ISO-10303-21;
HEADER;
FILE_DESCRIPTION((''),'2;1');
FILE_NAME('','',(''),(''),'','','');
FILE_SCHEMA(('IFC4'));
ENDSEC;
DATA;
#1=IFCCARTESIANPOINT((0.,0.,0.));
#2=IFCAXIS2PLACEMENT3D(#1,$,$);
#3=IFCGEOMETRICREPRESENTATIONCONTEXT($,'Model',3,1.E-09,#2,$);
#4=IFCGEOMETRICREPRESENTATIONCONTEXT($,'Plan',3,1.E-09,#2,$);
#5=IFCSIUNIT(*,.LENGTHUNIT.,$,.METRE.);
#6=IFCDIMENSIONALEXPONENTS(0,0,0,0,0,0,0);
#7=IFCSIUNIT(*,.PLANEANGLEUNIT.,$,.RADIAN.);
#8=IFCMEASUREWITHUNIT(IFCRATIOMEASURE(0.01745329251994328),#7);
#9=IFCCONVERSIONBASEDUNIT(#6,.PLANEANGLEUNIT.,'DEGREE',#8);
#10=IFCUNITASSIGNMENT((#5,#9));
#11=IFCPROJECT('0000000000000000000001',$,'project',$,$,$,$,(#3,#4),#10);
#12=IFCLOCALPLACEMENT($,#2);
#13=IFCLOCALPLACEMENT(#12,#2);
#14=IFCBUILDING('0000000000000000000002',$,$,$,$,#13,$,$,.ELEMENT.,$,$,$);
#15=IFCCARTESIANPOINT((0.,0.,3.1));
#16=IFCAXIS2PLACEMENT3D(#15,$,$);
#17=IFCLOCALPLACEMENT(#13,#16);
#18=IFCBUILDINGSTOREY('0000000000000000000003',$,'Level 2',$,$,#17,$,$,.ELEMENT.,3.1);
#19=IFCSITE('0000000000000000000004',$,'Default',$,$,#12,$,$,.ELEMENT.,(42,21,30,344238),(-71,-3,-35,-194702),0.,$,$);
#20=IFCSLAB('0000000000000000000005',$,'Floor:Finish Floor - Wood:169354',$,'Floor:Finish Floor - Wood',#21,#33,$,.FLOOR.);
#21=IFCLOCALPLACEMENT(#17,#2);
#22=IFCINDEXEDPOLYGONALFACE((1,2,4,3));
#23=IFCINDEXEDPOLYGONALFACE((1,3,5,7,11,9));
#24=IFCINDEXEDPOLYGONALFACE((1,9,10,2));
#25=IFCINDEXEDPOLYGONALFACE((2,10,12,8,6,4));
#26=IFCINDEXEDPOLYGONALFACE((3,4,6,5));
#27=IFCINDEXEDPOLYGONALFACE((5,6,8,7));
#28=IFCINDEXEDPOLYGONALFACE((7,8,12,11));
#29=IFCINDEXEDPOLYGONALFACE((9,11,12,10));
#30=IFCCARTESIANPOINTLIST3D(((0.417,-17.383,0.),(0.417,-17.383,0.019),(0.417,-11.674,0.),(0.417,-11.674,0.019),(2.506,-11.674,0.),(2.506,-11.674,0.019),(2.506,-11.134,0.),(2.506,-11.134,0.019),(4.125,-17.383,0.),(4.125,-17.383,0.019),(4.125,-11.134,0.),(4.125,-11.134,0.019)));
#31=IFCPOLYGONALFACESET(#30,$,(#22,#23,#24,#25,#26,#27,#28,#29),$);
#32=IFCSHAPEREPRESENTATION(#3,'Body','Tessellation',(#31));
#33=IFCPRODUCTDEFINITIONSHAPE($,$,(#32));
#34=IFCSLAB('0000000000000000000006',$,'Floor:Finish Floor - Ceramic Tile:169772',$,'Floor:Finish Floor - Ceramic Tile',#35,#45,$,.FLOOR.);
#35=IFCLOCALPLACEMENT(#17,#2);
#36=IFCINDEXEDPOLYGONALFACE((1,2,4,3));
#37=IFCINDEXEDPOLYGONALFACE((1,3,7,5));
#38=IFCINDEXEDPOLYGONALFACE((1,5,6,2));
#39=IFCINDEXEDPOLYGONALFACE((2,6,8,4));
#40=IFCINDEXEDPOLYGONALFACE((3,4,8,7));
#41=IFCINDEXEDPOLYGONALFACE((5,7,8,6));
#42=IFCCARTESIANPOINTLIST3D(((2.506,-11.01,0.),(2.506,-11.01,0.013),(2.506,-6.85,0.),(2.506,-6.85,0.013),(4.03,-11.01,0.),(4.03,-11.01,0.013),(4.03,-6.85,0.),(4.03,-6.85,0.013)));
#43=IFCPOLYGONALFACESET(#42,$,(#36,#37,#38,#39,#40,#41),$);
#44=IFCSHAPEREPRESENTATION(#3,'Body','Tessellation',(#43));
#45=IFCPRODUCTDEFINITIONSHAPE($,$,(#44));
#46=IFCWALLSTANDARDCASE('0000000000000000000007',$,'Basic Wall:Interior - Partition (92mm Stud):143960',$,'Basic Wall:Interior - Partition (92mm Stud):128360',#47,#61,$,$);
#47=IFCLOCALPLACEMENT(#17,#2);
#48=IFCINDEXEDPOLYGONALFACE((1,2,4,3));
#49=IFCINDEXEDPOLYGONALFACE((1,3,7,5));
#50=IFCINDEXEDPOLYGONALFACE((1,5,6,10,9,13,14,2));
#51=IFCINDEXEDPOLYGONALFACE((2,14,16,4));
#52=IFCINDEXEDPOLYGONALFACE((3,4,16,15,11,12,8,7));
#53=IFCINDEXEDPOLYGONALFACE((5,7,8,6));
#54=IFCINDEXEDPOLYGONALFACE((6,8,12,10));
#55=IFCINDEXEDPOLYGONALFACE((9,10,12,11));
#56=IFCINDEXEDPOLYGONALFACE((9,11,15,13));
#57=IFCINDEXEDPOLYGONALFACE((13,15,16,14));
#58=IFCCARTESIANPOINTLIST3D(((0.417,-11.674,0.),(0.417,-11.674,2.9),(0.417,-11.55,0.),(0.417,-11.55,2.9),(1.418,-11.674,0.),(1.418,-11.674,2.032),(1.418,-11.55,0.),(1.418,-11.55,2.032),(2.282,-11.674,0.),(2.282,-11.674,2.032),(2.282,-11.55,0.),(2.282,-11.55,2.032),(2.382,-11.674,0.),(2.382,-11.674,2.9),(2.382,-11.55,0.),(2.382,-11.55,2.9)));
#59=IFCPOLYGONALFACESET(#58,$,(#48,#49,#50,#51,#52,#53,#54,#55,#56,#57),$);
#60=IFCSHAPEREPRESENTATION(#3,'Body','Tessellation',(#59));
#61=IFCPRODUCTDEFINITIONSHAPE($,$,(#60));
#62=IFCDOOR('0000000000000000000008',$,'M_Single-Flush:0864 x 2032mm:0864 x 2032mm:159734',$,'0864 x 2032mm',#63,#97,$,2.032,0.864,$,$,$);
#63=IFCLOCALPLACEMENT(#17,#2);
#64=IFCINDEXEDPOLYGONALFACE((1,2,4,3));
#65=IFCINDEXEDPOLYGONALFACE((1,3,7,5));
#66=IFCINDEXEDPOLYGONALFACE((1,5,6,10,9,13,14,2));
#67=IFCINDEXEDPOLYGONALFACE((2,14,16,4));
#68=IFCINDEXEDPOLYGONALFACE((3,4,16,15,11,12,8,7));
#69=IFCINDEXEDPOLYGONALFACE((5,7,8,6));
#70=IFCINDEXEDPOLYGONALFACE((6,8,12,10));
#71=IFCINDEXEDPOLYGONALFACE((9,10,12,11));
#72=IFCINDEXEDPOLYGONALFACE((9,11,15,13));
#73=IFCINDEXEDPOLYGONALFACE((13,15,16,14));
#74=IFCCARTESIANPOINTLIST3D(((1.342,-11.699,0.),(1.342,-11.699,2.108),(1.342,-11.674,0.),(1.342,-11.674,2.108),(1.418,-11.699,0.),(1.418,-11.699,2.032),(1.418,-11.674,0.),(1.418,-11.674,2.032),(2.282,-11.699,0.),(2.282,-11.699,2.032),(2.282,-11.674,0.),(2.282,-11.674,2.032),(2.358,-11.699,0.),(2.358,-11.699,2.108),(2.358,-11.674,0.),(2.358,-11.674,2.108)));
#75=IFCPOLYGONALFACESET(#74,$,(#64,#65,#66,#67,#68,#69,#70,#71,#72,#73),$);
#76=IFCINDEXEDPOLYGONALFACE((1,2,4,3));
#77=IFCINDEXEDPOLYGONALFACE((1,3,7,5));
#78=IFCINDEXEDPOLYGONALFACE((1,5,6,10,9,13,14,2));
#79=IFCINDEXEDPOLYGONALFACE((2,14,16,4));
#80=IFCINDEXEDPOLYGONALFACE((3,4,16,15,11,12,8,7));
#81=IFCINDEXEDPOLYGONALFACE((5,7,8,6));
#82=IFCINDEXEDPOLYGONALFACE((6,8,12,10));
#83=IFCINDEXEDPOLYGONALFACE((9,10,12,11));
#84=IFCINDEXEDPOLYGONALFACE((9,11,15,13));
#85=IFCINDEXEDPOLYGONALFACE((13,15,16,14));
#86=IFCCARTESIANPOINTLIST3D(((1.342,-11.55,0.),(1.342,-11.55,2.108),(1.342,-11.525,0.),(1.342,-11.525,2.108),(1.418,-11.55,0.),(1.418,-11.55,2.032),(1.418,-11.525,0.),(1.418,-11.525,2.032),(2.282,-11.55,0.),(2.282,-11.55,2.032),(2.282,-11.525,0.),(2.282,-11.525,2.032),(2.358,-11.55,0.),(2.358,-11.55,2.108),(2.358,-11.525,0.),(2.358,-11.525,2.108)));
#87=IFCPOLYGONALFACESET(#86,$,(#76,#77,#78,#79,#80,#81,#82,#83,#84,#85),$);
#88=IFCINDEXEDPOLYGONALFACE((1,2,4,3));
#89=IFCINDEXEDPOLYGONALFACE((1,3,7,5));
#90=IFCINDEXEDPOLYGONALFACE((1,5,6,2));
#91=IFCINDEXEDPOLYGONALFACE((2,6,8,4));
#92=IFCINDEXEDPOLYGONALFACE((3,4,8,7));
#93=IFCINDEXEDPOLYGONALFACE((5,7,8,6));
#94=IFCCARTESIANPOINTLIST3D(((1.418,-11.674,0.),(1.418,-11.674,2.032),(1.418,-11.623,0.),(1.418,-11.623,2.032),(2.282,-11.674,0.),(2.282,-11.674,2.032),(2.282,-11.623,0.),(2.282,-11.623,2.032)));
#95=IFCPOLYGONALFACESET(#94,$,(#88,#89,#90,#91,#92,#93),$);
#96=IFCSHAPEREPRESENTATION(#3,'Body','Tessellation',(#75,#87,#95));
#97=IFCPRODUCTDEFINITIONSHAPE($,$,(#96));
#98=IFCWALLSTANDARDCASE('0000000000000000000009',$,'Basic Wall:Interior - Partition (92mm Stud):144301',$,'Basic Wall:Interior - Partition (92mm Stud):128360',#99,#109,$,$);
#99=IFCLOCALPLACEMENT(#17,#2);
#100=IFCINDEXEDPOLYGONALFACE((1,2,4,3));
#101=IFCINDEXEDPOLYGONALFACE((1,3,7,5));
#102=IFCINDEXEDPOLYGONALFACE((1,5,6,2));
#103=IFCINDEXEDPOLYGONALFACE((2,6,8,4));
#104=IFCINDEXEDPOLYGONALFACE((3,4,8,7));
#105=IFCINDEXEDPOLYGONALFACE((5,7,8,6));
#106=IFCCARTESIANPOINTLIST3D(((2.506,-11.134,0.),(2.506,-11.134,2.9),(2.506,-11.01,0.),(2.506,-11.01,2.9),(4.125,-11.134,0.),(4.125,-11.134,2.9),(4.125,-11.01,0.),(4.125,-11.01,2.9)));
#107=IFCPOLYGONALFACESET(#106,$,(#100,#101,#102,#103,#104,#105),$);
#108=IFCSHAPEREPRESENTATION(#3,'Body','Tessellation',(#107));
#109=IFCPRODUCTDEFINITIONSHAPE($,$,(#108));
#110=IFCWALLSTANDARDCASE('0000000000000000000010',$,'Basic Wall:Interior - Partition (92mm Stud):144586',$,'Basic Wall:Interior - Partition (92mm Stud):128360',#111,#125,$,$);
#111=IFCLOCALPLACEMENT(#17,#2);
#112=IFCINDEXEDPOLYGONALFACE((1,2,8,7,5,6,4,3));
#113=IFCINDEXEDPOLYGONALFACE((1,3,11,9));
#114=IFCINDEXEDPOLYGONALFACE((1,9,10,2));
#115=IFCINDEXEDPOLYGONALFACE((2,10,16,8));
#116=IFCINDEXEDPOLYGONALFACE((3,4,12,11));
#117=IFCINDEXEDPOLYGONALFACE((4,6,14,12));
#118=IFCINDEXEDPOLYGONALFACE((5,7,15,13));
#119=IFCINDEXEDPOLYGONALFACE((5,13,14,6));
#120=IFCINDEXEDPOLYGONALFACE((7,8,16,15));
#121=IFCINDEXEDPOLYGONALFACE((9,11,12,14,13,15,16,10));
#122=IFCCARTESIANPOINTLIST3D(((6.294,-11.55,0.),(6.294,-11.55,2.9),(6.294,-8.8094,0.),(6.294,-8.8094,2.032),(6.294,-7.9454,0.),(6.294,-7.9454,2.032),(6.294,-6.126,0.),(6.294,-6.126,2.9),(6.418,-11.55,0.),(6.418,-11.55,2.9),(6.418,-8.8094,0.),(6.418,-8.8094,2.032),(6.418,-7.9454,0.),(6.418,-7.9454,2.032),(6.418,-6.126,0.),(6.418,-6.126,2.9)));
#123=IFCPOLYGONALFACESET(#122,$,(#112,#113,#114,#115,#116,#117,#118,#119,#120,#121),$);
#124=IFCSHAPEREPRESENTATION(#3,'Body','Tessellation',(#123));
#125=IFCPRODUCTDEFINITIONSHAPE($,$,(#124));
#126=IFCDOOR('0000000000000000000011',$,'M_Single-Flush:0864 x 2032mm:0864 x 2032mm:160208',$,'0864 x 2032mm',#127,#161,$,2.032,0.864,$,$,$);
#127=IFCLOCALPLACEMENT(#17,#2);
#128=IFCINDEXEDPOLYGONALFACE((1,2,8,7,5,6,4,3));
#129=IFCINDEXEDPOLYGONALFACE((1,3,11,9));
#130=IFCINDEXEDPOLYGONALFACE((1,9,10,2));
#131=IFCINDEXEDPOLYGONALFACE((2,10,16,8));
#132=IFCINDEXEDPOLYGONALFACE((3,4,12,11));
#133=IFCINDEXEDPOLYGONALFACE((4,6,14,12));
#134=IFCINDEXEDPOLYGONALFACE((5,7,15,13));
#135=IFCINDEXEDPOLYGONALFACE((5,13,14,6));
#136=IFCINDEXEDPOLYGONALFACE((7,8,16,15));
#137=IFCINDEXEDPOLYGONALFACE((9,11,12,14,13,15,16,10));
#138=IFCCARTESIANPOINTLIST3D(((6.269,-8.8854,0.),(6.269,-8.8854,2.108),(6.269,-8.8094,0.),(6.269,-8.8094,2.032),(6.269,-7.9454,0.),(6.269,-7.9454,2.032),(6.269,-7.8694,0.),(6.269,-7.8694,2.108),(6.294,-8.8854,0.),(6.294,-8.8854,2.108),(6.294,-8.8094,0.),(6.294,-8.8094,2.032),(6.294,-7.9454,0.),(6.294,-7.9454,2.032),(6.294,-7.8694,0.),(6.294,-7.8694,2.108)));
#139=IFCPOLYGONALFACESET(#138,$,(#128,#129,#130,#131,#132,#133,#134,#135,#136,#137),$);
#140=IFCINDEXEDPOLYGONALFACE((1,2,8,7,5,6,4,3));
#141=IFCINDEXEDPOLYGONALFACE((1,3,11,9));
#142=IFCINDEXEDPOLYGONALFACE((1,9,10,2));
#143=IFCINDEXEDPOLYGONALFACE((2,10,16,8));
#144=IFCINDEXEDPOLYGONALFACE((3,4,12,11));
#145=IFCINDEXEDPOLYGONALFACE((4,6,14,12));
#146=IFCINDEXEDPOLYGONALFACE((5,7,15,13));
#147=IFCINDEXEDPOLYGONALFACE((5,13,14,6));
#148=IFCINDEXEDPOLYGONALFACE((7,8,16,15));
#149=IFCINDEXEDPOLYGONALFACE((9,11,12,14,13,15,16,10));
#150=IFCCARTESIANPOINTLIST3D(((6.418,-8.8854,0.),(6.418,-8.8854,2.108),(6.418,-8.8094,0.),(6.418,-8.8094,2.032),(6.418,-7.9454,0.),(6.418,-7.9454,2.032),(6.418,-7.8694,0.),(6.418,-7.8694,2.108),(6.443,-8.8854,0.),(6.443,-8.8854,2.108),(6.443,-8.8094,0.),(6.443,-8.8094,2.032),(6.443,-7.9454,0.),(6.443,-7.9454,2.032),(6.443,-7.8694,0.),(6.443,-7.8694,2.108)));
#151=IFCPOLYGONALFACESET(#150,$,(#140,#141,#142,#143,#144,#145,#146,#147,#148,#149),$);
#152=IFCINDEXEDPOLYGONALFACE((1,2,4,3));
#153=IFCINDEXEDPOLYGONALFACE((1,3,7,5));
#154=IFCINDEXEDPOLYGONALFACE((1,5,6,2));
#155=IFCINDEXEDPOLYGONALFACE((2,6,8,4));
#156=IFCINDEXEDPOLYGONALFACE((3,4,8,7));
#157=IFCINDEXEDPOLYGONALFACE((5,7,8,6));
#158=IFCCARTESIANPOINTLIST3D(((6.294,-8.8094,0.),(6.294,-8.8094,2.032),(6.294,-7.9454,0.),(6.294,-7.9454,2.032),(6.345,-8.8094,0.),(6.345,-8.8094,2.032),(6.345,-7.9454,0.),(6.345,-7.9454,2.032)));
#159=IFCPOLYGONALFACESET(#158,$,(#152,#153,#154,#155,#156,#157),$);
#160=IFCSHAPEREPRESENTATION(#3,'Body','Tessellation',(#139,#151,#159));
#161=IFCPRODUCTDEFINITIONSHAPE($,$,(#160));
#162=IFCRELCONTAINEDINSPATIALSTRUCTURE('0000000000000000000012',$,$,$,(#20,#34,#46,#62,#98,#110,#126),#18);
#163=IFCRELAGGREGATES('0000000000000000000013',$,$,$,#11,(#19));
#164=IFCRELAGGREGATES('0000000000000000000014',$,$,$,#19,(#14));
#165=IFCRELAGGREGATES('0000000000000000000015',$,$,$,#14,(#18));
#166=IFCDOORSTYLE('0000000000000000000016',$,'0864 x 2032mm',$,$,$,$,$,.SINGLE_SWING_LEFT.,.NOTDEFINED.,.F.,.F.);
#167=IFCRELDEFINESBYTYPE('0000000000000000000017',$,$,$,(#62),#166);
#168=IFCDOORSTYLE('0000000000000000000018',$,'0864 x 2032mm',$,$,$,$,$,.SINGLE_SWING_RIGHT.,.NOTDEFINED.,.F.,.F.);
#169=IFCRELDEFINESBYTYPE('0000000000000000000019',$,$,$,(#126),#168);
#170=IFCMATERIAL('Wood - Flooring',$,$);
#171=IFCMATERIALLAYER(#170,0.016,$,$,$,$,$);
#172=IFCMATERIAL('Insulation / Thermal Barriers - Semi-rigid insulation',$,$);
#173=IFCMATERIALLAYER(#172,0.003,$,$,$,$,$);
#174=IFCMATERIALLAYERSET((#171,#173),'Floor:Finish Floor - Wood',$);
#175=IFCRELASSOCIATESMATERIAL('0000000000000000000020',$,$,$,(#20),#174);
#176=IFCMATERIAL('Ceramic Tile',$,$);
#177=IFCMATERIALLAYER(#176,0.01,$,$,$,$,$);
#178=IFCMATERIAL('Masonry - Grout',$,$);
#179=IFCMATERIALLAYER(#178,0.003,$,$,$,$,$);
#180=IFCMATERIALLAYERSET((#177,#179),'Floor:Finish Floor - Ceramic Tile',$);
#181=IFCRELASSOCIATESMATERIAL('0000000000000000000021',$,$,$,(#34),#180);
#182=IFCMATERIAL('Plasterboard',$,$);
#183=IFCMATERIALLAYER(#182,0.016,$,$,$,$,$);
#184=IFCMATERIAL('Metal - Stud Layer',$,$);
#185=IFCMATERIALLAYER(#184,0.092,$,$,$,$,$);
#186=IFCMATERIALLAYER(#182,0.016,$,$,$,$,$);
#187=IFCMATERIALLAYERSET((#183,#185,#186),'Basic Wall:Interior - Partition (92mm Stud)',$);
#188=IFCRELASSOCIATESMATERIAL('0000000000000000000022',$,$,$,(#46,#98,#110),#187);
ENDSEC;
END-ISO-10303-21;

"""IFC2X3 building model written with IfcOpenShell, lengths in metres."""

from ifc_helpers import new_model, entity, si_unit, converted_unit, frame, frame_2d, origin, origin_2d_with_axis, place, context, project, spatial, polyline, rectangle, outline, extrude, source, transform, mapped, material, layer, layer_set, layer_usage, type_object, type_shapes, element, fill, save


model = new_model("IFC2X3")

# Units and contexts
model_context = context("Model", 3, precision=1e-09, world=origin())
plan_context = context("Plan", 3, precision=1e-09, world=origin())
ifc_project = project(units=[si_unit("LENGTHUNIT", "METRE"), converted_unit("PLANEANGLEUNIT", "DEGREE", entity("IfcRatioMeasure", 0.01745329251994328), si_unit("PLANEANGLEUNIT", "RADIAN"), dimensions=[0, 0, 0, 0, 0, 0, 0])], contexts=[model_context, plan_context])

# Site, building, storey
site_placement = place(None, origin())
site = spatial("IfcSite", under=ifc_project, at=site_placement, Name="Default", CompositionType="ELEMENT", RefLatitude=(42, 21, 30, 344238), RefLongitude=(-71, -3, -35, -194702), RefElevation=0.0)
building_placement = place(site_placement, origin())
building = spatial("IfcBuilding", under=site, at=building_placement, CompositionType="ELEMENT")
storey_placement = place(building_placement, frame((0.0, 0.0, 3.1)))
storey = spatial("IfcBuildingStorey", under=building, at=storey_placement, Name="Level 2", CompositionType="ELEMENT", Elevation=3.1)

# Slabs
ifc_material_1 = material(Name="Wood - Flooring")
ifc_layer_1 = layer(ifc_material_1, 0.016)
ifc_material_2 = material(Name="Insulation / Thermal Barriers - Semi-rigid insulation")
ifc_layer_2 = layer(ifc_material_2, 0.003)
ifc_layer_set_1 = layer_set([ifc_layer_1, ifc_layer_2], Name="Floor:Finish Floor - Wood")
ifc_layer_usage_1 = layer_usage(ifc_layer_set_1, "AXIS3", "POSITIVE", 0.0)
slab_1_placement = place(storey_placement, frame((0.417, -17.383, 0.0)))
element("IfcSlab", 1, at=slab_1_placement, inside=storey, material=ifc_layer_usage_1, Name="Floor:Finish Floor - Wood:169354", ObjectType="Floor:Finish Floor - Wood", PredefinedType="FLOOR", context=model_context, shape_type="SweptSolid", body=[
    extrude(outline(polyline([(-1.854, -3.1245), (1.854, -3.1245), (1.854, 2.5845), (-0.235, 2.5845), (-0.235, 3.1245), (-1.854, 3.1245), (-1.854, -3.1245)])), frame((1.854, 3.1245, 0.019), z_axis=(0.0, 0.0, -1.0), x_axis=(-1.0, 0.0, 0.0)), (0.0, 0.0, 1.0), 0.019),
])
ifc_material_3 = material(Name="Ceramic Tile")
ifc_layer_3 = layer(ifc_material_3, 0.01)
ifc_material_4 = material(Name="Masonry - Grout")
ifc_layer_4 = layer(ifc_material_4, 0.003)
ifc_layer_set_2 = layer_set([ifc_layer_3, ifc_layer_4], Name="Floor:Finish Floor - Ceramic Tile")
ifc_layer_usage_2 = layer_usage(ifc_layer_set_2, "AXIS3", "POSITIVE", 0.0)
slab_2_placement = place(storey_placement, frame((2.506, -11.01, 0.0)))
element("IfcSlab", 2, at=slab_2_placement, inside=storey, material=ifc_layer_usage_2, Name="Floor:Finish Floor - Ceramic Tile:169772", ObjectType="Floor:Finish Floor - Ceramic Tile", PredefinedType="FLOOR", context=model_context, shape_type="SweptSolid", body=[
    extrude(rectangle(XDim=4.16, YDim=1.524, at=frame_2d((0.0, 0.0), x_axis=(0.0, -1.0))), frame((0.762, 2.08, 0.013), z_axis=(0.0, 0.0, -1.0), x_axis=(-1.0, 0.0, 0.0)), (0.0, 0.0, 1.0), 0.013),
])

# Shared definitions
ifc_material_5 = material(Name="Metal - Stud Layer")
ifc_material_6 = material(Name="Plasterboard")

# Wall, opening, door
ifc_layer_5 = layer(ifc_material_6, 0.016)
ifc_layer_6 = layer(ifc_material_5, 0.092)
ifc_layer_7 = layer(ifc_material_6, 0.016)
ifc_layer_set_3 = layer_set([ifc_layer_5, ifc_layer_6, ifc_layer_7], Name="Basic Wall:Interior - Partition (92mm Stud)")
ifc_layer_usage_3 = layer_usage(ifc_layer_set_3, "AXIS2", "NEGATIVE", 0.062)
wall_1_placement = place(storey_placement, frame((2.382, -11.612, 0.0), z_axis=(0.0, 0.0, 1.0), x_axis=(-1.0, 0.0, 0.0)))
wall_1 = element("IfcWallStandardCase", 3, at=wall_1_placement, inside=storey, material=ifc_layer_usage_3, Name="Basic Wall:Interior - Partition (92mm Stud):143960", ObjectType="Basic Wall:Interior - Partition (92mm Stud):128360", context=model_context, shape_type="SweptSolid", body=[
    extrude(rectangle(XDim=1.965, YDim=0.124, at=frame_2d((0.9825, 0.0), x_axis=(-1.0, 0.0))), origin(), (0.0, 0.0, 1.0), 2.9),
])
opening_1_placement = place(wall_1_placement, frame((0.1, -0.062, 0.0)))
opening_1 = element("IfcOpeningElement", 4, at=opening_1_placement, cuts=wall_1, ObjectType="Opening", context=model_context, shape_type="SweptSolid", body=[
    extrude(rectangle(XDim=0.864, YDim=2.032, at=frame_2d((1.016, 0.432), x_axis=(0.0, -1.0))), frame((0.0, 0.0, 0.0), z_axis=(0.0, 1.0, 0.0), x_axis=(0.0, 0.0, 1.0)), (0.0, 0.0, 1.0), 0.124),
])
door_style_1 = type_object("IfcDoorStyle", Name="0864 x 2032mm", ConstructionType="NOTDEFINED", OperationType="SINGLE_SWING_LEFT", ParameterTakesPrecedence=False, Sizeable=False)
shared_shape_1 = source(origin(), model_context, "Body", "SweptSolid", [
    extrude(outline(polyline([(-0.508, -1.073), (0.508, -1.073), (0.508, 1.035), (0.432, 1.035), (0.432, -0.997), (-0.432, -0.997), (-0.432, 1.035), (-0.508, 1.035), (-0.508, -1.073)])), frame((0.432, 0.149, 1.035), z_axis=(0.0, -1.0, 0.0), x_axis=(-1.0, 0.0, 0.0)), (0.0, 0.0, 1.0), 0.025),
    extrude(outline(polyline([(-1.073, -0.508), (1.035, -0.508), (1.035, -0.432), (-0.997, -0.432), (-0.997, 0.432), (1.035, 0.432), (1.035, 0.508), (-1.073, 0.508), (-1.073, -0.508)])), frame((0.432, 0.0, 1.035), z_axis=(0.0, -1.0, 0.0), x_axis=(0.0, 0.0, -1.0)), (0.0, 0.0, 1.0), 0.025),
    extrude(rectangle(XDim=0.864, YDim=0.051, at=origin_2d_with_axis()), frame((0.432, 0.0985, 0.0)), (0.0, 0.0, 1.0), 2.032),
])
type_shapes(door_style_1, [shared_shape_1])
door_1_placement = place(opening_1_placement, origin())
door_1 = element("IfcDoor", 5, at=door_1_placement, inside=storey, type_object=door_style_1, Name="M_Single-Flush:0864 x 2032mm:0864 x 2032mm:159734", ObjectType="0864 x 2032mm", OverallHeight=2.032, OverallWidth=0.864, context=model_context, shape_type="MappedRepresentation", body=[
    mapped(shared_shape_1, transform((0.0, 0.0, 0.0), scale=1.0)),
])
fill(opening_1, door_1)

# Wall
ifc_layer_usage_4 = layer_usage(ifc_layer_set_3, "AXIS2", "NEGATIVE", 0.062)
wall_2_placement = place(storey_placement, frame((4.125, -11.072, 0.0), z_axis=(0.0, 0.0, 1.0), x_axis=(-1.0, 0.0, 0.0)))
element("IfcWallStandardCase", 6, at=wall_2_placement, inside=storey, material=ifc_layer_usage_4, Name="Basic Wall:Interior - Partition (92mm Stud):144301", ObjectType="Basic Wall:Interior - Partition (92mm Stud):128360", context=model_context, shape_type="SweptSolid", body=[
    extrude(rectangle(XDim=1.619, YDim=0.124, at=frame_2d((0.8095, 0.0), x_axis=(-1.0, 0.0))), origin(), (0.0, 0.0, 1.0), 2.9),
])

# Wall, opening, door
ifc_layer_usage_5 = layer_usage(ifc_layer_set_3, "AXIS2", "NEGATIVE", 0.062)
wall_3_placement = place(storey_placement, frame((6.356, -11.55, 0.0), z_axis=(0.0, 0.0, 1.0), x_axis=(0.0, 1.0, 0.0)))
wall_3 = element("IfcWallStandardCase", 7, at=wall_3_placement, inside=storey, material=ifc_layer_usage_5, Name="Basic Wall:Interior - Partition (92mm Stud):144586", ObjectType="Basic Wall:Interior - Partition (92mm Stud):128360", context=model_context, shape_type="SweptSolid", body=[
    extrude(rectangle(XDim=5.424, YDim=0.124, at=frame_2d((2.712, 0.0), x_axis=(-1.0, 0.0))), origin(), (0.0, 0.0, 1.0), 2.9),
])
opening_2_placement = place(wall_3_placement, frame((2.7406, -0.062, 0.0)))
opening_2 = element("IfcOpeningElement", 8, at=opening_2_placement, cuts=wall_3, ObjectType="Opening", context=model_context, shape_type="SweptSolid", body=[
    extrude(rectangle(XDim=0.864, YDim=2.032, at=frame_2d((1.016, 0.432), x_axis=(0.0, 1.0))), frame((0.0, 0.0, 0.0), z_axis=(0.0, 1.0, 0.0), x_axis=(0.0, 0.0, 1.0)), (0.0, 0.0, 1.0), 0.124),
])
door_style_2 = type_object("IfcDoorStyle", Name="0864 x 2032mm", ConstructionType="NOTDEFINED", OperationType="SINGLE_SWING_RIGHT", ParameterTakesPrecedence=False, Sizeable=False)
shared_shape_2 = source(origin(), model_context, "Body", "SweptSolid", [
    extrude(outline(polyline([(-0.508, -1.073), (0.508, -1.073), (0.508, 1.035), (0.432, 1.035), (0.432, -0.997), (-0.432, -0.997), (-0.432, 1.035), (-0.508, 1.035), (-0.508, -1.073)])), frame((0.432, 0.124, 1.035), z_axis=(0.0, 1.0, 0.0), x_axis=(1.0, 0.0, 0.0)), (0.0, 0.0, 1.0), 0.025),
    extrude(outline(polyline([(-1.073, -0.508), (1.035, -0.508), (1.035, -0.432), (-0.997, -0.432), (-0.997, 0.432), (1.035, 0.432), (1.035, 0.508), (-1.073, 0.508), (-1.073, -0.508)])), frame((0.432, -0.025, 1.035), z_axis=(0.0, 1.0, 0.0), x_axis=(0.0, 0.0, -1.0)), (0.0, 0.0, 1.0), 0.025),
    extrude(rectangle(XDim=0.051, YDim=0.864, at=origin_2d_with_axis()), frame((0.432, 0.0985, 0.0), z_axis=(0.0, 0.0, 1.0), x_axis=(0.0, 1.0, 0.0)), (0.0, 0.0, 1.0), 2.032),
])
type_shapes(door_style_2, [shared_shape_2])
door_2_placement = place(opening_2_placement, origin())
door_2 = element("IfcDoor", 9, at=door_2_placement, inside=storey, type_object=door_style_2, Name="M_Single-Flush:0864 x 2032mm:0864 x 2032mm:160208", ObjectType="0864 x 2032mm", OverallHeight=2.032, OverallWidth=0.864, context=model_context, shape_type="MappedRepresentation", body=[
    mapped(shared_shape_2, transform((0.0, 0.0, 0.0), scale=1.0)),
])
fill(opening_2, door_2)

save(model, "model.ifc")
